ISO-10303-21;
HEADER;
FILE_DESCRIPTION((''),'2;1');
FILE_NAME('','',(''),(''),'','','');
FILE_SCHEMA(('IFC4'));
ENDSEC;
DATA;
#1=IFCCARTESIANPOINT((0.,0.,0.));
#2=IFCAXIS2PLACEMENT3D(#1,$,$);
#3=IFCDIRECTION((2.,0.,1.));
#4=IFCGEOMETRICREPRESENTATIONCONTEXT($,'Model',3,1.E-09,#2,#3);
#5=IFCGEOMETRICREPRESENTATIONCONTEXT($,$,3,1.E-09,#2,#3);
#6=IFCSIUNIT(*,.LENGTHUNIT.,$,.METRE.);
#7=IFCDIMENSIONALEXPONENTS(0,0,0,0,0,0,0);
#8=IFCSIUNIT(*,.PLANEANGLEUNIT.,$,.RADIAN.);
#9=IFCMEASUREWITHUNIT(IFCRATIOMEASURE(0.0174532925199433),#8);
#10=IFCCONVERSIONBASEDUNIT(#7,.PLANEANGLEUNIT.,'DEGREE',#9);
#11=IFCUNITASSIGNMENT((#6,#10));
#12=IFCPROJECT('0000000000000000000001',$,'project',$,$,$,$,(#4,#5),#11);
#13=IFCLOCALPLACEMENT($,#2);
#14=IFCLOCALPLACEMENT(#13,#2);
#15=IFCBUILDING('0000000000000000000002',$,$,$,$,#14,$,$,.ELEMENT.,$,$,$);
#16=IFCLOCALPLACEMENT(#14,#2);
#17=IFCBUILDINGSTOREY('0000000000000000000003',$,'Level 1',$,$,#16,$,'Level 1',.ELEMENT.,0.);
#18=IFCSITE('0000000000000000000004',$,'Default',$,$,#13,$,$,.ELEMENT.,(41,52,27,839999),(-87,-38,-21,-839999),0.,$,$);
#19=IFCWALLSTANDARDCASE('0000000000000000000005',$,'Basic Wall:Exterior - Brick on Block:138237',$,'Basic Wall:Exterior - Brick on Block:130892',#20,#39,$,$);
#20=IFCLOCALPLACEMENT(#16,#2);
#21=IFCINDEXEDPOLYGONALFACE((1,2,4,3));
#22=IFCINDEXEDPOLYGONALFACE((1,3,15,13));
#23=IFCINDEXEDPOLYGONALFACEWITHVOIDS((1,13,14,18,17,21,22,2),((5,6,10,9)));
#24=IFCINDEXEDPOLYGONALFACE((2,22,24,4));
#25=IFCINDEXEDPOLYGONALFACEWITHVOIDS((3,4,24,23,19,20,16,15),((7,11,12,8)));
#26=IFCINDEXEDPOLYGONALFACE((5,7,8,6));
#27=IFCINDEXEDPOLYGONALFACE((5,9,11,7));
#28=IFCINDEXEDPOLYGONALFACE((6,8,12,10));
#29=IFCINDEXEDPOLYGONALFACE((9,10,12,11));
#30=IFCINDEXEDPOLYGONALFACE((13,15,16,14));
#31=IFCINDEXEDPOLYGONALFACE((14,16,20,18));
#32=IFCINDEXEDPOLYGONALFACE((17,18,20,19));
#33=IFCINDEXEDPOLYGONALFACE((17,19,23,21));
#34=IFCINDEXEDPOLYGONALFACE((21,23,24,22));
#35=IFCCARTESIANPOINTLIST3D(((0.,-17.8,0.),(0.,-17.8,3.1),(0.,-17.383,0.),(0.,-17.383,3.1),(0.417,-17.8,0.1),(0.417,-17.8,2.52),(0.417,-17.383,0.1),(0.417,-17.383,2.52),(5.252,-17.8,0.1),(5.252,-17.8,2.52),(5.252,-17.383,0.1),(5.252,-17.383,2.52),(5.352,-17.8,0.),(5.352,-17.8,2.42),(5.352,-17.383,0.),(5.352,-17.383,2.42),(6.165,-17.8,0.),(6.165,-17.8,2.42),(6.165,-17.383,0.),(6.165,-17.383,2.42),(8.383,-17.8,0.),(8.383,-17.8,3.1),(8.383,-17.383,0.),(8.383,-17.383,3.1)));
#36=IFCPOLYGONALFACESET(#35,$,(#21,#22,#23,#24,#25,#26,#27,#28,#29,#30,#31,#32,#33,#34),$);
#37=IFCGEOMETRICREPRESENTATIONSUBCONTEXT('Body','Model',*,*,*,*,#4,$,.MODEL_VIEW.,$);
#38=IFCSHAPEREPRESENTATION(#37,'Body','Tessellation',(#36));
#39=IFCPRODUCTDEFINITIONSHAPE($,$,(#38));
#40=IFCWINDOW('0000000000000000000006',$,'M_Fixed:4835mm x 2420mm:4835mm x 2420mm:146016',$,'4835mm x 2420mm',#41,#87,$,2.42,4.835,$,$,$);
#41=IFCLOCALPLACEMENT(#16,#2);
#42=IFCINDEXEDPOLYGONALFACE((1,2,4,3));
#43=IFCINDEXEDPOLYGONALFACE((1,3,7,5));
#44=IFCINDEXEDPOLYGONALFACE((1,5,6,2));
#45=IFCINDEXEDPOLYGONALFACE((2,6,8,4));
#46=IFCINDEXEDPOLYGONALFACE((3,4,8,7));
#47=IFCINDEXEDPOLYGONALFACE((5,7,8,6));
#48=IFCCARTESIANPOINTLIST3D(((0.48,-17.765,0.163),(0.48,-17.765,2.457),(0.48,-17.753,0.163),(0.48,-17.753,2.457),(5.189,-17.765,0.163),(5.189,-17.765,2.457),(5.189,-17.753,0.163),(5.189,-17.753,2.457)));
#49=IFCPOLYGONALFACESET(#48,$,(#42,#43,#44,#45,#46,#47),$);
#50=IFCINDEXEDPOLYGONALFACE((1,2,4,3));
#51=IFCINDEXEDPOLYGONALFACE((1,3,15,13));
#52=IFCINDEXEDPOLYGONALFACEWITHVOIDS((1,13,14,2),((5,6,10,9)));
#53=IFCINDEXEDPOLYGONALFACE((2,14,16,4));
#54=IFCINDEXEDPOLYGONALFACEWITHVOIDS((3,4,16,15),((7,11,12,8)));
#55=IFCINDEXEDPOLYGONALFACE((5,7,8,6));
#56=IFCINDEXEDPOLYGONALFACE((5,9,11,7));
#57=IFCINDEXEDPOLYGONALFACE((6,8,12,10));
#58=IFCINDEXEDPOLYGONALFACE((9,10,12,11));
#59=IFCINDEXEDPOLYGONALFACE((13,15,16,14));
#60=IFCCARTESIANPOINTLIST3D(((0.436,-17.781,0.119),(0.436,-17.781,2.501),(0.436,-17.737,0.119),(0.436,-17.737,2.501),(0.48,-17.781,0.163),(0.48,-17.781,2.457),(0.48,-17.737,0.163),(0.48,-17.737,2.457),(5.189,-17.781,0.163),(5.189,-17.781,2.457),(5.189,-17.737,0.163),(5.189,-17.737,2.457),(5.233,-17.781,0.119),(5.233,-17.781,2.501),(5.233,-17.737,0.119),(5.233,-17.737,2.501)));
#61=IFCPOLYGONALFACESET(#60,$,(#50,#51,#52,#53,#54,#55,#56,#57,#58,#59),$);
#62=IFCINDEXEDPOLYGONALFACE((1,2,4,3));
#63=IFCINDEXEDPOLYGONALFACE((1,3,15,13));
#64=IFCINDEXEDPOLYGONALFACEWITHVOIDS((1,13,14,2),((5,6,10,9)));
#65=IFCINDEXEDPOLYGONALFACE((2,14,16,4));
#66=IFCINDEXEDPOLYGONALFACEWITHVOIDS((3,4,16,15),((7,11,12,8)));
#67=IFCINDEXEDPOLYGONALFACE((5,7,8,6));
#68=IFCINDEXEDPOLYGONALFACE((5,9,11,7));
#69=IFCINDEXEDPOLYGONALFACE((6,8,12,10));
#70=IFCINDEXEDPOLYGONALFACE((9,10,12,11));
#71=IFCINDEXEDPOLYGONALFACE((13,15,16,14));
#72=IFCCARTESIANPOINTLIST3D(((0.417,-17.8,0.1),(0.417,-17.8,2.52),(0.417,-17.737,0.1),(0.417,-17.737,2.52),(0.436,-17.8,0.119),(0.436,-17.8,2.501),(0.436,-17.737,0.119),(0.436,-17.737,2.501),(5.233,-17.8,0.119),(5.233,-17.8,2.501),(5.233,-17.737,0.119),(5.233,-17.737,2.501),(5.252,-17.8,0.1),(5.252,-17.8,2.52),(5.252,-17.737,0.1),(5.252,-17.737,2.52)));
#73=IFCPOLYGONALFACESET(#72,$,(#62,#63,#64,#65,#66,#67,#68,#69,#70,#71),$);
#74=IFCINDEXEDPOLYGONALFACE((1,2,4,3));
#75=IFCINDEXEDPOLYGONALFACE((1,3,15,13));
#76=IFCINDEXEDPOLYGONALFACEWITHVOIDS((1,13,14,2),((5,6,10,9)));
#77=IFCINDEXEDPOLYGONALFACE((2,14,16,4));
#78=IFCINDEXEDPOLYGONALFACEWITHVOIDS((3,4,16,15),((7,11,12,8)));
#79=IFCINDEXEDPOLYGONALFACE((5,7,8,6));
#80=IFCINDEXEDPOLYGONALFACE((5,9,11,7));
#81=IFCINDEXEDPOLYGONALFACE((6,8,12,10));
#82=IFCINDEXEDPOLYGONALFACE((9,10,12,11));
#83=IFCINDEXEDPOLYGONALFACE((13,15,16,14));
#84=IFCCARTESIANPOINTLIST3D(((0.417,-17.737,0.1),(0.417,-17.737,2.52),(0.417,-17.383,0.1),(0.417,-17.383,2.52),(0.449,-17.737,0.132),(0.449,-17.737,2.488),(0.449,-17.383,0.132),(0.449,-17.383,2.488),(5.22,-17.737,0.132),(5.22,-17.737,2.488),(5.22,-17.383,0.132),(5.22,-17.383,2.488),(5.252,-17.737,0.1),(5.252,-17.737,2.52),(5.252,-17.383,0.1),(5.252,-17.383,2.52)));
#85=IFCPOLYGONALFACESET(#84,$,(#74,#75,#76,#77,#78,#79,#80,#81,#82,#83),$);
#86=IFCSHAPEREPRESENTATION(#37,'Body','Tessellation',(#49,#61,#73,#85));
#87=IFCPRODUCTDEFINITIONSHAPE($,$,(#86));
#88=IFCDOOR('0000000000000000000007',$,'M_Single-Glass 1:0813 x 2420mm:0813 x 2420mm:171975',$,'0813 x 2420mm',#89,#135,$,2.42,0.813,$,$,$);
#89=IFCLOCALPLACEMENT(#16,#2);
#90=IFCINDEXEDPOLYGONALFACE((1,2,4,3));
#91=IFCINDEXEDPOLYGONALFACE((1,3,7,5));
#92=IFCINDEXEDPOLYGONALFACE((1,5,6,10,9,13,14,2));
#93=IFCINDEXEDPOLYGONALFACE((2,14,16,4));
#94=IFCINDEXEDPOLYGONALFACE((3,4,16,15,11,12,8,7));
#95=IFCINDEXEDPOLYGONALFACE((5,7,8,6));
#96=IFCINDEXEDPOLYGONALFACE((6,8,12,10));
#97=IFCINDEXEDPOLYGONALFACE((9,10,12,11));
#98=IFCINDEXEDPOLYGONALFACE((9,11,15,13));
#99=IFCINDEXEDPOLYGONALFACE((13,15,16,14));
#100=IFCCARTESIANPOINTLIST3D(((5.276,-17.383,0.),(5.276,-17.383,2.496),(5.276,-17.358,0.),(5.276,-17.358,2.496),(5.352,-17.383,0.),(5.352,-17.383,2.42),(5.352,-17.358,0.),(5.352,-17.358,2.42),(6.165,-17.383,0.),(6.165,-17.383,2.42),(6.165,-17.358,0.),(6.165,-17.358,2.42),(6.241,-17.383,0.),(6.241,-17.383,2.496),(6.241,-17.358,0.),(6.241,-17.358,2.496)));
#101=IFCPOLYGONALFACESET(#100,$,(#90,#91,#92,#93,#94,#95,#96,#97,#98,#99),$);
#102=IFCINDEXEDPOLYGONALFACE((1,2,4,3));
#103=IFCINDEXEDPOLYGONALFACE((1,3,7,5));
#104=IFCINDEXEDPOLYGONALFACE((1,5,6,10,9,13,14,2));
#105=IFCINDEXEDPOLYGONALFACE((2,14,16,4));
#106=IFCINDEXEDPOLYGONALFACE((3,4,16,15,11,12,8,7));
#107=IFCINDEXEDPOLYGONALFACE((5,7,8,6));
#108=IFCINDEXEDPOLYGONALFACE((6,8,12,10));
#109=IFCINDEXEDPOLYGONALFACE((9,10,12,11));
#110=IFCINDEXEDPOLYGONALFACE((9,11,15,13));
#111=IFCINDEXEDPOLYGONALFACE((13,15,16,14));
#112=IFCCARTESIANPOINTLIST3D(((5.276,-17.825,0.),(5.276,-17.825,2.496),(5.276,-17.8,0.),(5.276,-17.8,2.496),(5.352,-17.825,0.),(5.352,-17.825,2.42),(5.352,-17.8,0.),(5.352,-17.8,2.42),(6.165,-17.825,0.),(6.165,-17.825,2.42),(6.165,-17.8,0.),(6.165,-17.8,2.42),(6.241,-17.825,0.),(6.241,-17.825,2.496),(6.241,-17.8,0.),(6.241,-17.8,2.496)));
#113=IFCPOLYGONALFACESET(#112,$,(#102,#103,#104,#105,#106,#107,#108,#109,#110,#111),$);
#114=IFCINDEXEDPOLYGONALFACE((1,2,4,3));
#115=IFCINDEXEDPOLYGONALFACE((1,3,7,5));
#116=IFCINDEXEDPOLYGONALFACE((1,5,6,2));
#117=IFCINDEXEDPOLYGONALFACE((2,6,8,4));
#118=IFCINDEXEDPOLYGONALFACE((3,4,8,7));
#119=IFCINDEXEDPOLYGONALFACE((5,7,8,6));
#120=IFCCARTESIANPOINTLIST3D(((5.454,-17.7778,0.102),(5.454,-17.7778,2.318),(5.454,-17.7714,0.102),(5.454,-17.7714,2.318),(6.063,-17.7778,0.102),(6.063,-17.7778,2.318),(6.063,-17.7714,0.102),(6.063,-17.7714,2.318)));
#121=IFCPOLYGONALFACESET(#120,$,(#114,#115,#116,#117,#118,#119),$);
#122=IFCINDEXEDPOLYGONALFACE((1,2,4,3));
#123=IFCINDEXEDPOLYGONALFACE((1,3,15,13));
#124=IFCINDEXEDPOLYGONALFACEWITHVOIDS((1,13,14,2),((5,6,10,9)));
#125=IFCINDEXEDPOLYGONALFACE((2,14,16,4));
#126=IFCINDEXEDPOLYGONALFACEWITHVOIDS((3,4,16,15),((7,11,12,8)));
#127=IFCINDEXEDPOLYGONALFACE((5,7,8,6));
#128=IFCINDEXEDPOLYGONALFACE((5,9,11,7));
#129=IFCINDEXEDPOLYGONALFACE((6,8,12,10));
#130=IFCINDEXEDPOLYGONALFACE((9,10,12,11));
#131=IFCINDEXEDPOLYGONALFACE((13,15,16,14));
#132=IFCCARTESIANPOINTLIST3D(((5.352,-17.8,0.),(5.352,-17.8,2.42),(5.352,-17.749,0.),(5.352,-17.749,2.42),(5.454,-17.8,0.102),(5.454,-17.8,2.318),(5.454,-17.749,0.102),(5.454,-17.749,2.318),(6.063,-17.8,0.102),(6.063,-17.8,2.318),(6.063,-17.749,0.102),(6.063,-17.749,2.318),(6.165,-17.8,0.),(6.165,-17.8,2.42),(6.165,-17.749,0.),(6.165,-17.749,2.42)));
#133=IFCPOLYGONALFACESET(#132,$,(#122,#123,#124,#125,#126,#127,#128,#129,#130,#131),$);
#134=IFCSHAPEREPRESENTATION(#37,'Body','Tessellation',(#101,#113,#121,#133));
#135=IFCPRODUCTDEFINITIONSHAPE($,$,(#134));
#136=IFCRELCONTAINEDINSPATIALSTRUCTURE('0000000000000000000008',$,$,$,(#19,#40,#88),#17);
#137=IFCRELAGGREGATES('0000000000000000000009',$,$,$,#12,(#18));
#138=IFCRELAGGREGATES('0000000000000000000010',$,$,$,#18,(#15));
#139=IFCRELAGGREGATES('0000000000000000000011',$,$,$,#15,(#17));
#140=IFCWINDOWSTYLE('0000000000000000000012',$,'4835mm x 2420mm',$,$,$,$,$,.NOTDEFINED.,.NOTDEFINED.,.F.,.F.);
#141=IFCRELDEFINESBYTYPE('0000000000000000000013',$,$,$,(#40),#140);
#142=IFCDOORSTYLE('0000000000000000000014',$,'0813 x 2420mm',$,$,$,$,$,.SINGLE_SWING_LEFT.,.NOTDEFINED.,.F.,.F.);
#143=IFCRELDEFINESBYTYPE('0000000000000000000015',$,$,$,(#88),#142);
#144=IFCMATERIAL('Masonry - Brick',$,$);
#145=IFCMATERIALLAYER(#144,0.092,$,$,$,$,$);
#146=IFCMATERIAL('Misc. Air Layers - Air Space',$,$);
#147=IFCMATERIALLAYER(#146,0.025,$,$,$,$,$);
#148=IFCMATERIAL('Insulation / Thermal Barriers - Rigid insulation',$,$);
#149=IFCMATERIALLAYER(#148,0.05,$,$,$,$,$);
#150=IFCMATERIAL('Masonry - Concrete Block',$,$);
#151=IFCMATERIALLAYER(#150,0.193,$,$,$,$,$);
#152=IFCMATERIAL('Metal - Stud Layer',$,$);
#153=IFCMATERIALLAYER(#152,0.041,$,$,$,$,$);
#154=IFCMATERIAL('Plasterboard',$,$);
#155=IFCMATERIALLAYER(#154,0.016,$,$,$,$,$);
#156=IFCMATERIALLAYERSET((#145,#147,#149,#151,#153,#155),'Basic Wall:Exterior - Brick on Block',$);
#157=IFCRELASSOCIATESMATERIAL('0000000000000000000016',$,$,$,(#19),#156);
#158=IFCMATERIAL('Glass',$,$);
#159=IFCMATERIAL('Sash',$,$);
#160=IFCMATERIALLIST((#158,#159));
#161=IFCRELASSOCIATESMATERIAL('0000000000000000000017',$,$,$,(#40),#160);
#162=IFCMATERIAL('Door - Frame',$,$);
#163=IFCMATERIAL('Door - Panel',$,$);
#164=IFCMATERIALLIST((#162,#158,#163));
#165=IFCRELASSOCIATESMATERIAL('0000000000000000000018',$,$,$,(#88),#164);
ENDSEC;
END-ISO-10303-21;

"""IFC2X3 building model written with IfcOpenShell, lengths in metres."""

from ifc_helpers import new_model, entity, si_unit, converted_unit, direction, frame, frame_2d, origin, origin_2d_with_axis, place, context, subcontext, project, spatial, polyline, rectangle, outline, extrude, source, transform, mapped, material, material_list, layer, layer_set, layer_usage, type_object, type_shapes, element, fill, save


model = new_model("IFC2X3")

# Units and contexts
model_context = context("Model", 3, precision=1e-09, world=origin(), true_north=direction((2.0, 0.0, 1.0)))
context_of_model = context(None, 3, precision=1e-09, world=origin(), true_north=direction((2.0, 0.0, 1.0)))
body_context = subcontext(model_context, "Body", "Model", "MODEL_VIEW")
ifc_project = project(units=[si_unit("LENGTHUNIT", "METRE"), converted_unit("PLANEANGLEUNIT", "DEGREE", entity("IfcRatioMeasure", 0.0174532925199433), si_unit("PLANEANGLEUNIT", "RADIAN"), dimensions=[0, 0, 0, 0, 0, 0, 0])], contexts=[model_context, context_of_model])

# Site, building, storey
site_placement = place(None, origin())
site = spatial("IfcSite", under=ifc_project, at=site_placement, Name="Default", CompositionType="ELEMENT", RefLatitude=(41, 52, 27, 839999), RefLongitude=(-87, -38, -21, -839999), RefElevation=0.0)
building_placement = place(site_placement, origin())
building = spatial("IfcBuilding", under=site, at=building_placement, CompositionType="ELEMENT")
storey_placement = place(building_placement, origin())
storey = spatial("IfcBuildingStorey", under=building, at=storey_placement, Name="Level 1", LongName="Level 1", CompositionType="ELEMENT", Elevation=0.0)

# Wall, openings, window, door
ifc_material_1 = material(Name="Masonry - Brick")
ifc_layer_1 = layer(ifc_material_1, 0.092)
ifc_material_2 = material(Name="Misc. Air Layers - Air Space")
ifc_layer_2 = layer(ifc_material_2, 0.025)
ifc_material_3 = material(Name="Insulation / Thermal Barriers - Rigid insulation")
ifc_layer_3 = layer(ifc_material_3, 0.05)
ifc_material_4 = material(Name="Masonry - Concrete Block")
ifc_layer_4 = layer(ifc_material_4, 0.193)
ifc_material_5 = material(Name="Metal - Stud Layer")
ifc_layer_5 = layer(ifc_material_5, 0.041)
ifc_material_6 = material(Name="Plasterboard")
ifc_layer_6 = layer(ifc_material_6, 0.016)
ifc_layer_set_1 = layer_set([ifc_layer_1, ifc_layer_2, ifc_layer_3, ifc_layer_4, ifc_layer_5, ifc_layer_6], Name="Basic Wall:Exterior - Brick on Block")
ifc_layer_usage_1 = layer_usage(ifc_layer_set_1, "AXIS2", "NEGATIVE", 0.2085)
wall_1_placement = place(storey_placement, frame((8.383, -17.5915, 0.0), z_axis=(0.0, 0.0, 1.0), x_axis=(-1.0, 0.0, 0.0)))
wall_1 = element("IfcWallStandardCase", 1, at=wall_1_placement, inside=storey, material=ifc_layer_usage_1, Name="Basic Wall:Exterior - Brick on Block:138237", ObjectType="Basic Wall:Exterior - Brick on Block:130892", context=body_context, shape_type="SweptSolid", body=[
    extrude(rectangle(XDim=8.383, YDim=0.417, at=frame_2d((4.1915, 0.0), x_axis=(-1.0, 0.0))), origin(), (0.0, 0.0, 1.0), 3.1),
])
opening_1_placement = place(wall_1_placement, frame((3.131, -0.2085, 0.1)))
opening_1 = element("IfcOpeningElement", 2, at=opening_1_placement, cuts=wall_1, ObjectType="Opening", context=body_context, shape_type="SweptSolid", body=[
    extrude(rectangle(XDim=2.42, YDim=4.835, at=frame_2d((1.21, 2.4175), x_axis=(1.0, 0.0))), frame((0.0, 0.0, 0.0), z_axis=(0.0, 1.0, 0.0), x_axis=(0.0, 0.0, 1.0)), (0.0, 0.0, 1.0), 0.417),
])
opening_2_placement = place(wall_1_placement, frame((2.218, -0.2085, 0.0)))
opening_2 = element("IfcOpeningElement", 3, at=opening_2_placement, cuts=wall_1, ObjectType="Opening", context=body_context, shape_type="SweptSolid", body=[
    extrude(rectangle(XDim=0.813, YDim=2.42, at=frame_2d((1.21, 0.4065), x_axis=(0.0, -1.0))), frame((0.0, 0.0, 0.0), z_axis=(0.0, 1.0, 0.0), x_axis=(0.0, 0.0, 1.0)), (0.0, 0.0, 1.0), 0.417),
])
ifc_material_7 = material(Name="Glass")
ifc_material_8 = material(Name="Sash")
ifc_material_list_1 = material_list([ifc_material_7, ifc_material_8])
window_style_1 = type_object("IfcWindowStyle", Name="4835mm x 2420mm", ConstructionType="NOTDEFINED", OperationType="NOTDEFINED", ParameterTakesPrecedence=False, Sizeable=False)
shared_shape_1 = source(origin(), body_context, "Body", "SweptSolid", [
    extrude(rectangle(XDim=0.012, YDim=4.709, at=origin_2d_with_axis()), frame((2.4175, 0.376, 0.063), z_axis=(0.0, 0.0, 1.0), x_axis=(0.0, -1.0, 0.0)), (0.0, 0.0, 1.0), 2.294),
    extrude(outline(polyline([(-2.3985, -1.191), (2.3985, -1.191), (2.3985, 1.191), (-2.3985, 1.191), (-2.3985, -1.191)]), holes=[polyline([(-2.3545, -1.147), (-2.3545, 1.147), (2.3545, 1.147), (2.3545, -1.147), (-2.3545, -1.147)])]), frame((2.4175, 0.354, 1.21), z_axis=(0.0, 1.0, 0.0), x_axis=(1.0, 0.0, 0.0)), (0.0, 0.0, 1.0), 0.044),
    extrude(outline(polyline([(-2.4175, -1.21), (2.4175, -1.21), (2.4175, 1.21), (-2.4175, 1.21), (-2.4175, -1.21)]), holes=[polyline([(-2.3985, -1.191), (-2.3985, 1.191), (2.3985, 1.191), (2.3985, -1.191), (-2.3985, -1.191)])]), frame((2.4175, 0.354, 1.21), z_axis=(0.0, 1.0, 0.0), x_axis=(1.0, 0.0, 0.0)), (0.0, 0.0, 1.0), 0.063),
    extrude(outline(polyline([(-2.4175, -1.21), (2.4175, -1.21), (2.4175, 1.21), (-2.4175, 1.21), (-2.4175, -1.21)]), holes=[polyline([(-2.3855, -1.178), (-2.3855, 1.178), (2.3855, 1.178), (2.3855, -1.178), (-2.3855, -1.178)])]), frame((2.4175, 0.0, 1.21), z_axis=(0.0, 1.0, 0.0), x_axis=(1.0, 0.0, 0.0)), (0.0, 0.0, 1.0), 0.354),
])
type_shapes(window_style_1, [shared_shape_1])
window_1_placement = place(opening_1_placement, origin())
window_1 = element("IfcWindow", 4, at=window_1_placement, inside=storey, type_object=window_style_1, material=ifc_material_list_1, Name="M_Fixed:4835mm x 2420mm:4835mm x 2420mm:146016", ObjectType="4835mm x 2420mm", OverallHeight=2.42, OverallWidth=4.835, context=body_context, shape_type="MappedRepresentation", body=[
    mapped(shared_shape_1, transform((0.0, 0.0, 0.0), scale=1.0)),
])
fill(opening_1, window_1)
ifc_material_9 = material(Name="Door - Frame")
ifc_material_10 = material(Name="Door - Panel")
ifc_material_list_2 = material_list([ifc_material_9, ifc_material_7, ifc_material_10])
door_style_1 = type_object("IfcDoorStyle", Name="0813 x 2420mm", ConstructionType="NOTDEFINED", OperationType="SINGLE_SWING_LEFT", ParameterTakesPrecedence=False, Sizeable=False)
shared_shape_2 = source(origin(), body_context, "Body", "SweptSolid", [
    extrude(outline(polyline([(-0.4065, -1.191), (-0.4065, 1.229), (-0.4825, 1.229), (-0.4825, -1.267), (0.4825, -1.267), (0.4825, 1.229), (0.4065, 1.229), (0.4065, -1.191), (-0.4065, -1.191)])), frame((0.4065, 0.0, 1.229), z_axis=(0.0, 1.0, 0.0), x_axis=(1.0, 0.0, 0.0)), (0.0, 0.0, -1.0), 0.025),
    extrude(outline(polyline([(-0.4065, -1.191), (-0.4065, 1.229), (-0.4825, 1.229), (-0.4825, -1.267), (0.4825, -1.267), (0.4825, 1.229), (0.4065, 1.229), (0.4065, -1.191), (-0.4065, -1.191)])), frame((0.4065, 0.442, 1.229), z_axis=(0.0, 1.0, 0.0), x_axis=(1.0, 0.0, 0.0)), (0.0, 0.0, -1.0), 0.025),
    extrude(rectangle(XDim=0.609, YDim=0.0064, at=frame_2d((0.0, 0.0), x_axis=(1.0, 0.0))), frame((0.4065, 0.3916, 0.102)), (0.0, 0.0, 1.0), 2.216),
    extrude(outline(polyline([(-1.21, -0.4065), (1.21, -0.4065), (1.21, 0.4065), (-1.21, 0.4065), (-1.21, -0.4065)]), holes=[polyline([(-1.108, 0.3045), (1.108, 0.3045), (1.108, -0.3045), (-1.108, -0.3045), (-1.108, 0.3045)])]), frame((0.4065, 0.417, 1.21), z_axis=(0.0, -1.0, 0.0), x_axis=(0.0, 0.0, -1.0)), (0.0, 0.0, 1.0), 0.051),
])
type_shapes(door_style_1, [shared_shape_2])
door_1_placement = place(opening_2_placement, origin())
door_1 = element("IfcDoor", 5, at=door_1_placement, inside=storey, type_object=door_style_1, material=ifc_material_list_2, Name="M_Single-Glass 1:0813 x 2420mm:0813 x 2420mm:171975", ObjectType="0813 x 2420mm", OverallHeight=2.42, OverallWidth=0.813, context=body_context, shape_type="MappedRepresentation", body=[
    mapped(shared_shape_2, transform((0.0, 0.0, 0.0), scale=1.0)),
])
fill(opening_2, door_1)

save(model, "model.ifc")
